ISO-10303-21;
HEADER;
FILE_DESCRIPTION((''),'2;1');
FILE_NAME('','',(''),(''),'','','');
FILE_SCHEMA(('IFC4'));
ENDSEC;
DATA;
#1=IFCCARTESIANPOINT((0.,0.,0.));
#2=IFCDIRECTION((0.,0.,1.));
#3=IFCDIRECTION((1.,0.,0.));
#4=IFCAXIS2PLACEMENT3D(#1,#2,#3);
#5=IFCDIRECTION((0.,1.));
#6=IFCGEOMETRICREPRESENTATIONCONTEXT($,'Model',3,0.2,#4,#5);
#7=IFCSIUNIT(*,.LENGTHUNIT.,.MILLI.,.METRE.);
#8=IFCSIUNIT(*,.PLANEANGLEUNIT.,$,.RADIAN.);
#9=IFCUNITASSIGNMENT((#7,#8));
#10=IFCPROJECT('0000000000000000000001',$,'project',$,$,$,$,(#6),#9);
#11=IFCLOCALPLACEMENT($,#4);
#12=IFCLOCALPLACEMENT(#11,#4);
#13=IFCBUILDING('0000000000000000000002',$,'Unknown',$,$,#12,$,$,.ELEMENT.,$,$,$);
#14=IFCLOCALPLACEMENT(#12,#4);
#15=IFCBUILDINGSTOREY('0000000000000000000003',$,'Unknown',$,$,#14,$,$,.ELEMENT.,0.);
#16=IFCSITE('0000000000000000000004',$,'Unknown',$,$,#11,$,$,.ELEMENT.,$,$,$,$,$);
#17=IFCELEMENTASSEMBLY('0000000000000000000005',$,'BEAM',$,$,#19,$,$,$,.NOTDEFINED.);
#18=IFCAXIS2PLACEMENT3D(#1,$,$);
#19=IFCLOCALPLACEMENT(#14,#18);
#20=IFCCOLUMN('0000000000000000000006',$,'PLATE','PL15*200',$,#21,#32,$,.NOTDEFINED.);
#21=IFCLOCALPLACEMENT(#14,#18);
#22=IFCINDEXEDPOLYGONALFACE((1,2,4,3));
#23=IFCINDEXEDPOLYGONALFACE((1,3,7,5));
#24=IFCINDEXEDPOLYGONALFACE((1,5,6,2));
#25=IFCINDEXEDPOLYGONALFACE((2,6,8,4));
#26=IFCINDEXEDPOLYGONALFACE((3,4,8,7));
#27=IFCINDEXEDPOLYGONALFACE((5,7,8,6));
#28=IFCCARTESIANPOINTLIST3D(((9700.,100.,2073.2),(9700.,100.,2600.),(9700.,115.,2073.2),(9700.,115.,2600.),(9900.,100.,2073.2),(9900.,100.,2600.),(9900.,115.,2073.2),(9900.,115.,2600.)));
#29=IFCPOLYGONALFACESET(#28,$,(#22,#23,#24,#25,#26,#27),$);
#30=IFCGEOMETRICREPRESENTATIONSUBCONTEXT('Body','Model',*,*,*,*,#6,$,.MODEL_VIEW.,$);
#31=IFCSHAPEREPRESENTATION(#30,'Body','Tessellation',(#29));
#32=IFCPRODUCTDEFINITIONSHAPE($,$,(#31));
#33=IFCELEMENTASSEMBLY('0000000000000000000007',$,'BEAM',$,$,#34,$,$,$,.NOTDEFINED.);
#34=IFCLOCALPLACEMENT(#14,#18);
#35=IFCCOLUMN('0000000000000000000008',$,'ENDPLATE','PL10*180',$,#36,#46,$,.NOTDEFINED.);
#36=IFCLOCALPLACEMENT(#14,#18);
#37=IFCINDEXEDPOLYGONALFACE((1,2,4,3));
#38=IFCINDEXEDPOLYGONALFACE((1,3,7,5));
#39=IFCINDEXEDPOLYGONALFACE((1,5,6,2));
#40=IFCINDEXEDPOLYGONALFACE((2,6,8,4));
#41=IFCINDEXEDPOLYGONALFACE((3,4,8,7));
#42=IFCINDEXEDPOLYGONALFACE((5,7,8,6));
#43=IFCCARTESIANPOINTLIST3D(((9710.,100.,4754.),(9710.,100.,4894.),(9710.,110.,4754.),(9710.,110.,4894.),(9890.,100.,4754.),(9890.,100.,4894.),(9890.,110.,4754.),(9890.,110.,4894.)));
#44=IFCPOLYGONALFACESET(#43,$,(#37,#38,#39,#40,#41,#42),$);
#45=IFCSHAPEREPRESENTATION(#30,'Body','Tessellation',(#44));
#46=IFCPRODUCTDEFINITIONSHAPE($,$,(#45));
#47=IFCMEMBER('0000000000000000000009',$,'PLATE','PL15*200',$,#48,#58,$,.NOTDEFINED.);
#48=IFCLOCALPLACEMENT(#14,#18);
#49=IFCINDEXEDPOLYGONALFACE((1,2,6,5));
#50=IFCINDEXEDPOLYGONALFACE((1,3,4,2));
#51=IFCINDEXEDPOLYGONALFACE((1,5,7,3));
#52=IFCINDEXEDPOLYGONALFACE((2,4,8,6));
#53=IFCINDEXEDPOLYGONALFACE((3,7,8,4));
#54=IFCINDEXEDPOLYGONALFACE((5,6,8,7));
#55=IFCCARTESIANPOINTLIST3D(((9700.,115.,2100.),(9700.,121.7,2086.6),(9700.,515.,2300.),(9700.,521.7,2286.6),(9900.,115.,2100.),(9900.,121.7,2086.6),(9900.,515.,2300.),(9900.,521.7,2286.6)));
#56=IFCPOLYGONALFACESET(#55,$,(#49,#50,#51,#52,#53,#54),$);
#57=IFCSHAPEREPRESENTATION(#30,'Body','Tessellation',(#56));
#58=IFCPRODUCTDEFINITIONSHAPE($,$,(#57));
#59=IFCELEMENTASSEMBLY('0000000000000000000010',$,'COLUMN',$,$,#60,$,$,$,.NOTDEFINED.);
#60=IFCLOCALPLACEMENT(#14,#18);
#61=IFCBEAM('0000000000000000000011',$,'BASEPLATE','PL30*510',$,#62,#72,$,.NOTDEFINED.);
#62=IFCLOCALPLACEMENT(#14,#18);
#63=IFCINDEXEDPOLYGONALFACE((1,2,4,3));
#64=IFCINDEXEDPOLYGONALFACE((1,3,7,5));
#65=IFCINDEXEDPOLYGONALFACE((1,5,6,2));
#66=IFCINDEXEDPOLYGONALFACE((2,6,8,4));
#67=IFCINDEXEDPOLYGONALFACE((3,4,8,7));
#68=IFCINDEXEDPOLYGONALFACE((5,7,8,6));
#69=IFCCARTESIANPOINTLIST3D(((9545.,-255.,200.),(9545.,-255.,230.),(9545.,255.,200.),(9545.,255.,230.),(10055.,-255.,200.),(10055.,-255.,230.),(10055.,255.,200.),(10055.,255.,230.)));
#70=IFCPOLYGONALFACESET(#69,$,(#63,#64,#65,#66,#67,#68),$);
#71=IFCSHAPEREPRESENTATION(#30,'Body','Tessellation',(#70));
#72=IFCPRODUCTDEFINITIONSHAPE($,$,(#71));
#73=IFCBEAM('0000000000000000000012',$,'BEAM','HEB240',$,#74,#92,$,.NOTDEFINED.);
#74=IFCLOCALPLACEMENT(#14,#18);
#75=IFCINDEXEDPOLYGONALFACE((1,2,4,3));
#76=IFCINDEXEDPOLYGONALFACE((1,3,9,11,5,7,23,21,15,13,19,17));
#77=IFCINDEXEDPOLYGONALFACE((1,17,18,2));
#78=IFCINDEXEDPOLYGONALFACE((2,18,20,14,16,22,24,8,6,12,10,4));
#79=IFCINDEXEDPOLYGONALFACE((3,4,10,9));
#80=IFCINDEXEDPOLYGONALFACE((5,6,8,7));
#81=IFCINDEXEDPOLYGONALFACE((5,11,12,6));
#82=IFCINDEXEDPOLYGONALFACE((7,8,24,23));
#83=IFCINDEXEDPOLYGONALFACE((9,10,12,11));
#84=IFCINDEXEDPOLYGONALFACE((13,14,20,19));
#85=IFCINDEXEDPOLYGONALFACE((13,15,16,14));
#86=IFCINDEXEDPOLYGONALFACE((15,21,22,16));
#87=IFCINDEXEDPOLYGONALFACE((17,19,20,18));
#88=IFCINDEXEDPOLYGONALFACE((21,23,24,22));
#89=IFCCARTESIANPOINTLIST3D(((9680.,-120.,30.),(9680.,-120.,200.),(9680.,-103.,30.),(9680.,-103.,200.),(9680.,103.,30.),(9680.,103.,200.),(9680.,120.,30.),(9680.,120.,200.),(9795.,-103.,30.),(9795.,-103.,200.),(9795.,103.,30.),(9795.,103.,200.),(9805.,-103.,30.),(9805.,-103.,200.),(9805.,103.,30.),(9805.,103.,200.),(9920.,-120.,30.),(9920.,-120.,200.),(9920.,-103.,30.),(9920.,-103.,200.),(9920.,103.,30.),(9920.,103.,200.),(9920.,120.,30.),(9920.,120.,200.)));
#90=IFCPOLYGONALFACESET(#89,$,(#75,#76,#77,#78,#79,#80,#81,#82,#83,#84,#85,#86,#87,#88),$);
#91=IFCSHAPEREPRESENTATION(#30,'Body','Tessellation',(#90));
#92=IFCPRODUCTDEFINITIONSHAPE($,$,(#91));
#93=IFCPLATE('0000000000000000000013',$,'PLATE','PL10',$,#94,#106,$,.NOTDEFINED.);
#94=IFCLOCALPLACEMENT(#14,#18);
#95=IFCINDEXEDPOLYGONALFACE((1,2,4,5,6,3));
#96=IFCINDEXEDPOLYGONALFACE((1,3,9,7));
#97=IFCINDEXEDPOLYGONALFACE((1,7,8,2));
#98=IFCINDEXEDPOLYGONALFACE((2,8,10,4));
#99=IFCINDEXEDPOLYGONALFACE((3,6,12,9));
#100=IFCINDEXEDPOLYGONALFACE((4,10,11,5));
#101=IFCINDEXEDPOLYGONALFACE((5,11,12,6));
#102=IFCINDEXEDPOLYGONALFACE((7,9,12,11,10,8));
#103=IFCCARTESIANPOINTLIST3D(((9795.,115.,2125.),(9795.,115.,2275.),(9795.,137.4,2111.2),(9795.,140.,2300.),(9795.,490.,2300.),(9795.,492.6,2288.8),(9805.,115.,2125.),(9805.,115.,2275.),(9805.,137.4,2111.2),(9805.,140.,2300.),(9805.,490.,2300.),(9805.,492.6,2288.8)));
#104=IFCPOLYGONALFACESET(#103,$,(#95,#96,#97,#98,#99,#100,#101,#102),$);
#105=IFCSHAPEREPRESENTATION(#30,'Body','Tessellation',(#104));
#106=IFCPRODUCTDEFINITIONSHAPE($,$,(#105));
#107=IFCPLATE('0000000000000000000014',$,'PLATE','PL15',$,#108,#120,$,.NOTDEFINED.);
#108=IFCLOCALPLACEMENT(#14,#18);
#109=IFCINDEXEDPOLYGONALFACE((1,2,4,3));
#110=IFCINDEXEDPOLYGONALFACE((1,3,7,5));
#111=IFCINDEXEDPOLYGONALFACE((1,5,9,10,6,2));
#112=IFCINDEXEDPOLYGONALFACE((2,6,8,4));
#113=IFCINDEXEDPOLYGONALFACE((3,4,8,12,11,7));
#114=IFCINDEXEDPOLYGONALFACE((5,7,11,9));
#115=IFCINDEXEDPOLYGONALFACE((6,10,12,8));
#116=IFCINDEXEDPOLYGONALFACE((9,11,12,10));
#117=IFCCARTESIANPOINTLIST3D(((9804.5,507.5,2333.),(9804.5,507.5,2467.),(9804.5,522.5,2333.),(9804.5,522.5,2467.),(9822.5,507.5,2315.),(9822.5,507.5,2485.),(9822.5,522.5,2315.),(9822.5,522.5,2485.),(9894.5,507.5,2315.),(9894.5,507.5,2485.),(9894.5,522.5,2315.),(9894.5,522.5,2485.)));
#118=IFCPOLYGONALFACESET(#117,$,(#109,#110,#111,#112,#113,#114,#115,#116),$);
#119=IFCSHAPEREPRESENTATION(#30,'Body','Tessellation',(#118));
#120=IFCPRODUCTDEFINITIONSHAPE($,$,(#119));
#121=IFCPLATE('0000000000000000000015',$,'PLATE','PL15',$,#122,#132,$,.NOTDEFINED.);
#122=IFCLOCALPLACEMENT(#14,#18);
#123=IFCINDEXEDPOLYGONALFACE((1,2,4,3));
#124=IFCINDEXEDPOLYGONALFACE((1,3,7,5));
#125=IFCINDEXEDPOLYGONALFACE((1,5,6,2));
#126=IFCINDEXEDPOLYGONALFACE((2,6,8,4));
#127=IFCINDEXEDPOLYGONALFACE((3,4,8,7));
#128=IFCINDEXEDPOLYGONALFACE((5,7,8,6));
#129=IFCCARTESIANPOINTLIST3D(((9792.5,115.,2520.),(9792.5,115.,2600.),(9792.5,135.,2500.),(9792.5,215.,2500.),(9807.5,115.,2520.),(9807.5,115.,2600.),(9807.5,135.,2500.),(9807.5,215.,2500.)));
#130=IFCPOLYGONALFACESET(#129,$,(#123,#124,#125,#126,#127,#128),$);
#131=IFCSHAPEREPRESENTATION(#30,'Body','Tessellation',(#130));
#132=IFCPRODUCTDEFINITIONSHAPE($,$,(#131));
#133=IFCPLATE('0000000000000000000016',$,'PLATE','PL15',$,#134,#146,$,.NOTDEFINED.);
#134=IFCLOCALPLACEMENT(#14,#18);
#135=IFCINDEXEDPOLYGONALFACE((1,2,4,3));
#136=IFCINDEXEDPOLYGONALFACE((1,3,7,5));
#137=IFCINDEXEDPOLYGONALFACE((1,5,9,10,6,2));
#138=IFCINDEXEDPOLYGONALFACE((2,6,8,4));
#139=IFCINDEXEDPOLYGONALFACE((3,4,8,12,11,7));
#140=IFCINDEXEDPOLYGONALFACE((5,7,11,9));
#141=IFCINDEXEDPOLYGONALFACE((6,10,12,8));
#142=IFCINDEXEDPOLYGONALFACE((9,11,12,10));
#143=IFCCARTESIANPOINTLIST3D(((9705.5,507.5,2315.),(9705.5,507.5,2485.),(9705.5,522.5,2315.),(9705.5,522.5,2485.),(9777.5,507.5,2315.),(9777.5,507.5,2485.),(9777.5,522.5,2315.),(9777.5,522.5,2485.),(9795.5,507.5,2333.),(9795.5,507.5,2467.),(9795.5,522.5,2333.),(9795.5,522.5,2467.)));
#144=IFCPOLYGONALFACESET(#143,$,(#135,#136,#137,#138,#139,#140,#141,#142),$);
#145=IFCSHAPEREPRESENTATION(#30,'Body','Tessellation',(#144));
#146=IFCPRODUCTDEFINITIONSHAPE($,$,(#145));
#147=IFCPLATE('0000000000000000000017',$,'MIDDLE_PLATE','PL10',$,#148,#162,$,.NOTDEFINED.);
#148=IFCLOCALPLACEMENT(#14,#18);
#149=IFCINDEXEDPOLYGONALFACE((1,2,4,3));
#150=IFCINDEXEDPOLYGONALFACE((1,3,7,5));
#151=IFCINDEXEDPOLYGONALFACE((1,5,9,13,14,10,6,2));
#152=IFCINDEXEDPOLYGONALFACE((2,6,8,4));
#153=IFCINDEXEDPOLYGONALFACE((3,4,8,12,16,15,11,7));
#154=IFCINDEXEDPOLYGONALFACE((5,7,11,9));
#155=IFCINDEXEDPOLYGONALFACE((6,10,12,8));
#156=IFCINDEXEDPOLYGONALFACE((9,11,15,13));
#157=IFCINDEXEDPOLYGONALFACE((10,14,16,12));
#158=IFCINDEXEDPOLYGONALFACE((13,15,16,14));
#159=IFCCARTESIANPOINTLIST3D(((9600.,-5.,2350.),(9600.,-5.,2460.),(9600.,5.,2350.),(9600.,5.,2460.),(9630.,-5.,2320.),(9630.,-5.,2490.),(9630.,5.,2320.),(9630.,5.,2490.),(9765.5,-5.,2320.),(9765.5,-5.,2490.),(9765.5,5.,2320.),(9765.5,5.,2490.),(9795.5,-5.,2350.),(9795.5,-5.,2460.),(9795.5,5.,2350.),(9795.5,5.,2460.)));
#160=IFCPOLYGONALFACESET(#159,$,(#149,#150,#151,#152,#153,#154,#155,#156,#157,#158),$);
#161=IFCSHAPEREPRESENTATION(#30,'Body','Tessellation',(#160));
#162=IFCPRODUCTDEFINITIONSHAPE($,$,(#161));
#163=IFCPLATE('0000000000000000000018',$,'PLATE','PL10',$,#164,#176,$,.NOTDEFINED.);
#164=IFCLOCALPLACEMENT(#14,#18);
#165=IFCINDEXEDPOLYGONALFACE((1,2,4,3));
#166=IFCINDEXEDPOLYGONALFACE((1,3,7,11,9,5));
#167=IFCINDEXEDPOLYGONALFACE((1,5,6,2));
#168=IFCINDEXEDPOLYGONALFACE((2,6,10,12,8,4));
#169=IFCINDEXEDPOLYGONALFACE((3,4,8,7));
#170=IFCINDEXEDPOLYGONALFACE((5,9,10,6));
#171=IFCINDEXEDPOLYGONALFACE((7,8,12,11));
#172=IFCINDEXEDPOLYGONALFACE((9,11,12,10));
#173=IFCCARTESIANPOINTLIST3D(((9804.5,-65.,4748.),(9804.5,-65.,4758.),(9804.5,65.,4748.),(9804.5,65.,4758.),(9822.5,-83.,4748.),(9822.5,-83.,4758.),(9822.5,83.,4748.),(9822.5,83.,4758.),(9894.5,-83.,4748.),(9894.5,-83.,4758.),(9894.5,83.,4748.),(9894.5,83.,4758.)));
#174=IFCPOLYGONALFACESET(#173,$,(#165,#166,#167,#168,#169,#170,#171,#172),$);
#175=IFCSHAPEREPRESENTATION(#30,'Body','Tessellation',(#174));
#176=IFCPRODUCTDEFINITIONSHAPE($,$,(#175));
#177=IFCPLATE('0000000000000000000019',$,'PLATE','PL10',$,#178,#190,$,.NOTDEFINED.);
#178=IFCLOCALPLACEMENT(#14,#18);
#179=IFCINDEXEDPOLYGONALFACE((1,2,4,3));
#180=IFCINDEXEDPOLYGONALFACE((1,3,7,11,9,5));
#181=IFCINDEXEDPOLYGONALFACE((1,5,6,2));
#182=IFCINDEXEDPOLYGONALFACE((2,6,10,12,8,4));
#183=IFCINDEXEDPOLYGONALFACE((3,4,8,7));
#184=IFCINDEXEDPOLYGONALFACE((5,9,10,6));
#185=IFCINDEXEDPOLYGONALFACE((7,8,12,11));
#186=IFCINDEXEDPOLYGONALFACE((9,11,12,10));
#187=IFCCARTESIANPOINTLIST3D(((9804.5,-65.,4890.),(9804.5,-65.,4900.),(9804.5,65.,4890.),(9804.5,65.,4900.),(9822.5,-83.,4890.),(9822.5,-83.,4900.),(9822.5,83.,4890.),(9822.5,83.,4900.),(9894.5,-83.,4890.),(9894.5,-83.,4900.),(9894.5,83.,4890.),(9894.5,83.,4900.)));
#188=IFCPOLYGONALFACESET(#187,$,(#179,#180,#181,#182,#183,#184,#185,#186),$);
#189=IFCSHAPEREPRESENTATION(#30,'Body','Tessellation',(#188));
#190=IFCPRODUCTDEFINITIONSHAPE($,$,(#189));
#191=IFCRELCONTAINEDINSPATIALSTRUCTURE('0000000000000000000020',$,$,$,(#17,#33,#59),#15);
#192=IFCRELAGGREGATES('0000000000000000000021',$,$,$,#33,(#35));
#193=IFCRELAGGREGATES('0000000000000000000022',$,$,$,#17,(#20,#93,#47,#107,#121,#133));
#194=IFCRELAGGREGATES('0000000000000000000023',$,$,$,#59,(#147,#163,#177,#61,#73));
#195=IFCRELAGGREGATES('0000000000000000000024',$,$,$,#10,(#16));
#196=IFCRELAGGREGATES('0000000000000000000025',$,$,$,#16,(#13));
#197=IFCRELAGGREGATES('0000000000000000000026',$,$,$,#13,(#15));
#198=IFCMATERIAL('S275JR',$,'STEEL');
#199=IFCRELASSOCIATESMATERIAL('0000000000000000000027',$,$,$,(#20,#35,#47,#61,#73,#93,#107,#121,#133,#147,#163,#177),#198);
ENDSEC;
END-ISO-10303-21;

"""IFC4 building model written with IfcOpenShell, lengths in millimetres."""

from ifc_helpers import new_model, si_unit, direction, frame, origin_with_axes, place, context, subcontext, project, spatial, line, indexed_curve, outline, extrude, material, element, aggregate, save


model = new_model("IFC4")

# Units and contexts
model_context = context("Model", 3, precision=0.2, world=origin_with_axes(), true_north=direction((0.0, 1.0)))
body_context = subcontext(model_context, "Body", "Model", "MODEL_VIEW")
ifc_project = project(units=[si_unit("LENGTHUNIT", "METRE", prefix="MILLI"), si_unit("PLANEANGLEUNIT", "RADIAN")], contexts=[model_context])

# Site, building, storey
site_placement = place(None, origin_with_axes())
site = spatial("IfcSite", under=ifc_project, at=site_placement, Name="Unknown", CompositionType="ELEMENT")
building_placement = place(site_placement, origin_with_axes())
building = spatial("IfcBuilding", under=site, at=building_placement, Name="Unknown", CompositionType="ELEMENT")
storey_placement = place(building_placement, origin_with_axes())
storey = spatial("IfcBuildingStorey", under=building, at=storey_placement, Name="Unknown", CompositionType="ELEMENT", Elevation=0.0)

# Element assemblies, columns
assembly_1_placement = place(storey_placement, frame((9800.0, 0.0, 2400.0), z_axis=(1.0, 0.0, 0.0), x_axis=(0.0, 1.0, 0.0)))
assembly_1 = element("IfcElementAssembly", 1, at=assembly_1_placement, inside=storey, Name="BEAM", PredefinedType="NOTDEFINED")
ifc_material_1 = material(Name="S275JR", Category="STEEL")
column_1_placement = place(assembly_1_placement, frame((107.5, -326.8, 0.0), z_axis=(1.0, 0.0, 0.0), x_axis=(0.0, 1.0, 0.0)))
column_1 = element("IfcColumn", 2, at=column_1_placement, material=ifc_material_1, Name="PLATE", Description="PL15*200", PredefinedType="NOTDEFINED", context=body_context, shape_type="SolidModel", body=[
    extrude(outline(indexed_curve([(-7.5, -100.0), (7.5, -100.0), (7.5, 100.0), (-7.5, 100.0)], segments=[line(1, 2, 3, 4, 1)])), frame((0.0, 0.0, 0.0), z_axis=(-1.0, 0.0, 0.0), x_axis=(0.0, 0.0, 1.0)), (0.0, -0.000002, -1.0), 526.8),
])
assembly_2_placement = place(storey_placement, frame((9800.0, 3600.0, 4824.0), z_axis=(-1.0, 0.0, 0.0), x_axis=(-0.000002, -1.0, 0.0)))
assembly_2 = element("IfcElementAssembly", 3, at=assembly_2_placement, inside=storey, Name="BEAM", PredefinedType="NOTDEFINED")
column_2_placement = place(assembly_2_placement, frame((3495.0, -70.0, 0.0), z_axis=(-1.0, 0.0, 0.0), x_axis=(0.0, 1.0, 0.0)))
column_2 = element("IfcColumn", 4, at=column_2_placement, material=ifc_material_1, Name="ENDPLATE", Description="PL10*180", PredefinedType="NOTDEFINED", context=body_context, shape_type="SolidModel", body=[
    extrude(outline(indexed_curve([(-5.0, -90.0), (5.0, -90.0), (5.0, 90.0), (-5.0, 90.0)], segments=[line(1, 2, 3, 4, 1)])), frame((0.0, 0.0, 0.0), z_axis=(-1.0, 0.0, 0.0), x_axis=(0.0, 0.0, 1.0)), (0.0, -0.000002, -1.0), 140.0),
])
aggregate(assembly_2, [column_2])

# Member
member_placement = place(assembly_1_placement, frame((118.4, -306.7, 0.0), z_axis=(0.447214, -0.894427, 0.0), x_axis=(0.894427, 0.447214, 0.0)))
member = element("IfcMember", 5, at=member_placement, material=ifc_material_1, Name="PLATE", Description="PL15*200", PredefinedType="NOTDEFINED", context=body_context, shape_type="SolidModel", body=[
    extrude(outline(indexed_curve([(-7.5, -100.0), (7.5, -100.0), (7.5, 100.0), (-7.5, 100.0)], segments=[line(1, 2, 3, 4, 1)])), frame((0.0, 0.0, 0.0), z_axis=(-1.0, 0.0, 0.0), x_axis=(0.0, 0.0, 1.0)), (0.0, -0.000002, -1.0), 447.2),
])

# Element assembly, beams
assembly_3_placement = place(storey_placement, frame((9800.0, 0.0, 200.0), z_axis=(-1.0, 0.0, 0.0), x_axis=(0.0, 0.0, 1.0)))
assembly_3 = element("IfcElementAssembly", 6, at=assembly_3_placement, inside=storey, Name="COLUMN", PredefinedType="NOTDEFINED")
beam_1_placement = place(assembly_3_placement, frame((15.0, -255.0, 0.0), z_axis=(1.0, 0.0, 0.0), x_axis=(0.0, 1.0, 0.0)))
beam_1 = element("IfcBeam", 7, at=beam_1_placement, material=ifc_material_1, Name="BASEPLATE", Description="PL30*510", PredefinedType="NOTDEFINED", context=body_context, shape_type="SolidModel", body=[
    extrude(outline(indexed_curve([(-15.0, -255.0), (15.0, -255.0), (15.0, 255.0), (-15.0, 255.0)], segments=[line(1, 2, 3, 4, 1)])), frame((0.0, 0.0, 0.0), z_axis=(-1.0, 0.0, 0.0), x_axis=(0.0, 0.0, 1.0)), (0.0, -0.000002, -1.0), 510.0),
])
beam_2_placement = place(assembly_3_placement, frame((0.0, 0.0, 0.0), z_axis=(0.0, -0.000002, -1.0), x_axis=(-1.0, 0.0, 0.0)))
beam_2 = element("IfcBeam", 8, at=beam_2_placement, material=ifc_material_1, Name="BEAM", Description="HEB240", PredefinedType="NOTDEFINED", context=body_context, shape_type="SolidModel", body=[
    extrude(outline(indexed_curve([(-120.0, -120.0), (120.0, -120.0), (120.0, -103.0), (5.0, -103.0), (5.0, 103.0), (120.0, 103.0), (120.0, 120.0), (-120.0, 120.0), (-120.0, 103.0), (-5.0, 103.0), (-5.0, -103.0), (-120.0, -103.0)], segments=[line(1, 2, 3, 4, 5, 6, 7, 8, 9, 10, 11, 12, 1)])), frame((0.0, 0.0, 0.0), z_axis=(-1.0, 0.0, 0.0), x_axis=(0.0, 0.0, 1.0)), (0.0, -0.000002, -1.0), 170.0),
])

# Plates
plate_1_placement = place(assembly_1_placement, frame((115.0, -300.0, 0.0), z_axis=(0.0, -0.000002, -1.0), x_axis=(0.0, 1.0, 0.0)))
plate_1 = element("IfcPlate", 9, at=plate_1_placement, material=ifc_material_1, Name="PLATE", Description="PL10", PredefinedType="NOTDEFINED", context=body_context, shape_type="SolidModel", body=[
    extrude(outline(indexed_curve([(11.2, 22.4), (25.0, 0.0), (175.0, 0.0), (200.0, 25.0), (200.0, 375.0), (188.8, 377.6)], segments=[line(1, 2, 3, 4, 5, 6, 1)])), frame((0.0, 0.0, 5.0), z_axis=(0.0, 0.0, 1.0), x_axis=(1.0, 0.0, 0.0)), (0.0, -0.000002, -1.0), 10.0),
])
plate_2_placement = place(assembly_1_placement, frame((515.0, -85.0, 4.5), z_axis=(-1.0, 0.0, 0.0), x_axis=(0.0, 0.0, 1.0)))
plate_2 = element("IfcPlate", 10, at=plate_2_placement, material=ifc_material_1, Name="PLATE", Description="PL15", PredefinedType="NOTDEFINED", context=body_context, shape_type="SolidModel", body=[
    extrude(outline(indexed_curve([(0.0, 18.0), (18.0, 0.0), (90.0, 0.0), (90.0, 170.0), (18.0, 170.0), (0.0, 152.0)], segments=[line(1, 2, 3, 4, 5, 6, 1)])), frame((0.0, 0.0, 7.5), z_axis=(0.0, 0.0, 1.0), x_axis=(1.0, 0.0, 0.0)), (0.0, -0.000002, -1.0), 15.0),
])
plate_3_placement = place(assembly_1_placement, frame((115.0, 100.0, 0.0), z_axis=(0.0, -0.000002, -1.0), x_axis=(0.0, 1.0, 0.0)))
plate_3 = element("IfcPlate", 11, at=plate_3_placement, material=ifc_material_1, Name="PLATE", Description="PL15", PredefinedType="NOTDEFINED", context=body_context, shape_type="SolidModel", body=[
    extrude(outline(indexed_curve([(0.0, 20.0), (20.0, 0.0), (100.0, 0.0), (100.0, 0.0), (0.0, 100.0), (0.0, 100.0)], segments=[line(1, 2, 3, 4, 5, 6, 1)])), frame((0.0, 0.0, 7.5), z_axis=(0.0, 0.0, 1.0), x_axis=(1.0, 0.0, 0.0)), (0.0, -0.000002, -1.0), 15.0),
])
plate_4_placement = place(assembly_1_placement, frame((515.0, -85.0, -4.5), z_axis=(1.0, 0.0, 0.0), x_axis=(0.0, -0.000002, -1.0)))
plate_4 = element("IfcPlate", 12, at=plate_4_placement, material=ifc_material_1, Name="PLATE", Description="PL15", PredefinedType="NOTDEFINED", context=body_context, shape_type="SolidModel", body=[
    extrude(outline(indexed_curve([(0.0, 18.0), (18.0, 0.0), (90.0, 0.0), (90.0, 170.0), (18.0, 170.0), (0.0, 152.0)], segments=[line(1, 2, 3, 4, 5, 6, 1)])), frame((0.0, 0.0, 7.5), z_axis=(0.0, 0.0, 1.0), x_axis=(1.0, 0.0, 0.0)), (0.0, -0.000002, -1.0), 15.0),
])
plate_5_placement = place(assembly_3_placement, frame((2290.0, 0.0, 200.0), z_axis=(0.0, 1.0, 0.0), x_axis=(0.0, -0.000002, -1.0)))
plate_5 = element("IfcPlate", 13, at=plate_5_placement, material=ifc_material_1, Name="MIDDLE_PLATE", Description="PL10", PredefinedType="NOTDEFINED", context=body_context, shape_type="SolidModel", body=[
    extrude(outline(indexed_curve([(0.0, 30.0), (30.0, 0.0), (165.5, 0.0), (195.5, 30.0), (195.5, 140.0), (165.5, 170.0), (30.0, 170.0), (0.0, 140.0)], segments=[line(1, 2, 3, 4, 5, 6, 7, 8, 1)])), frame((0.0, 0.0, 5.0), z_axis=(0.0, 0.0, 1.0), x_axis=(1.0, 0.0, 0.0)), (0.0, -0.000002, -1.0), 10.0),
])
plate_6_placement = place(assembly_3_placement, frame((4553.0, 83.0, -4.5), z_axis=(-1.0, 0.0, 0.0), x_axis=(0.0, -0.000002, -1.0)))
plate_6 = element("IfcPlate", 14, at=plate_6_placement, material=ifc_material_1, Name="PLATE", Description="PL10", PredefinedType="NOTDEFINED", context=body_context, shape_type="SolidModel", body=[
    extrude(outline(indexed_curve([(0.0, 18.0), (18.0, 0.0), (90.0, 0.0), (90.0, 166.0), (18.0, 166.0), (0.0, 148.0)], segments=[line(1, 2, 3, 4, 5, 6, 1)])), frame((0.0, 0.0, 5.0), z_axis=(0.0, 0.0, 1.0), x_axis=(1.0, 0.0, 0.0)), (0.0, -0.000002, -1.0), 10.0),
])
plate_7_placement = place(assembly_3_placement, frame((4695.0, 83.0, -4.5), z_axis=(-1.0, 0.0, 0.0), x_axis=(0.0, -0.000002, -1.0)))
plate_7 = element("IfcPlate", 15, at=plate_7_placement, material=ifc_material_1, Name="PLATE", Description="PL10", PredefinedType="NOTDEFINED", context=body_context, shape_type="SolidModel", body=[
    extrude(outline(indexed_curve([(0.0, 18.0), (18.0, 0.0), (90.0, 0.0), (90.0, 166.0), (18.0, 166.0), (0.0, 148.0)], segments=[line(1, 2, 3, 4, 5, 6, 1)])), frame((0.0, 0.0, 5.0), z_axis=(0.0, 0.0, 1.0), x_axis=(1.0, 0.0, 0.0)), (0.0, -0.000002, -1.0), 10.0),
])

aggregate(assembly_1, [column_1, plate_1, member, plate_2, plate_3, plate_4])

aggregate(assembly_3, [plate_5, plate_6, plate_7, beam_1, beam_2])

save(model, "model.ifc")
